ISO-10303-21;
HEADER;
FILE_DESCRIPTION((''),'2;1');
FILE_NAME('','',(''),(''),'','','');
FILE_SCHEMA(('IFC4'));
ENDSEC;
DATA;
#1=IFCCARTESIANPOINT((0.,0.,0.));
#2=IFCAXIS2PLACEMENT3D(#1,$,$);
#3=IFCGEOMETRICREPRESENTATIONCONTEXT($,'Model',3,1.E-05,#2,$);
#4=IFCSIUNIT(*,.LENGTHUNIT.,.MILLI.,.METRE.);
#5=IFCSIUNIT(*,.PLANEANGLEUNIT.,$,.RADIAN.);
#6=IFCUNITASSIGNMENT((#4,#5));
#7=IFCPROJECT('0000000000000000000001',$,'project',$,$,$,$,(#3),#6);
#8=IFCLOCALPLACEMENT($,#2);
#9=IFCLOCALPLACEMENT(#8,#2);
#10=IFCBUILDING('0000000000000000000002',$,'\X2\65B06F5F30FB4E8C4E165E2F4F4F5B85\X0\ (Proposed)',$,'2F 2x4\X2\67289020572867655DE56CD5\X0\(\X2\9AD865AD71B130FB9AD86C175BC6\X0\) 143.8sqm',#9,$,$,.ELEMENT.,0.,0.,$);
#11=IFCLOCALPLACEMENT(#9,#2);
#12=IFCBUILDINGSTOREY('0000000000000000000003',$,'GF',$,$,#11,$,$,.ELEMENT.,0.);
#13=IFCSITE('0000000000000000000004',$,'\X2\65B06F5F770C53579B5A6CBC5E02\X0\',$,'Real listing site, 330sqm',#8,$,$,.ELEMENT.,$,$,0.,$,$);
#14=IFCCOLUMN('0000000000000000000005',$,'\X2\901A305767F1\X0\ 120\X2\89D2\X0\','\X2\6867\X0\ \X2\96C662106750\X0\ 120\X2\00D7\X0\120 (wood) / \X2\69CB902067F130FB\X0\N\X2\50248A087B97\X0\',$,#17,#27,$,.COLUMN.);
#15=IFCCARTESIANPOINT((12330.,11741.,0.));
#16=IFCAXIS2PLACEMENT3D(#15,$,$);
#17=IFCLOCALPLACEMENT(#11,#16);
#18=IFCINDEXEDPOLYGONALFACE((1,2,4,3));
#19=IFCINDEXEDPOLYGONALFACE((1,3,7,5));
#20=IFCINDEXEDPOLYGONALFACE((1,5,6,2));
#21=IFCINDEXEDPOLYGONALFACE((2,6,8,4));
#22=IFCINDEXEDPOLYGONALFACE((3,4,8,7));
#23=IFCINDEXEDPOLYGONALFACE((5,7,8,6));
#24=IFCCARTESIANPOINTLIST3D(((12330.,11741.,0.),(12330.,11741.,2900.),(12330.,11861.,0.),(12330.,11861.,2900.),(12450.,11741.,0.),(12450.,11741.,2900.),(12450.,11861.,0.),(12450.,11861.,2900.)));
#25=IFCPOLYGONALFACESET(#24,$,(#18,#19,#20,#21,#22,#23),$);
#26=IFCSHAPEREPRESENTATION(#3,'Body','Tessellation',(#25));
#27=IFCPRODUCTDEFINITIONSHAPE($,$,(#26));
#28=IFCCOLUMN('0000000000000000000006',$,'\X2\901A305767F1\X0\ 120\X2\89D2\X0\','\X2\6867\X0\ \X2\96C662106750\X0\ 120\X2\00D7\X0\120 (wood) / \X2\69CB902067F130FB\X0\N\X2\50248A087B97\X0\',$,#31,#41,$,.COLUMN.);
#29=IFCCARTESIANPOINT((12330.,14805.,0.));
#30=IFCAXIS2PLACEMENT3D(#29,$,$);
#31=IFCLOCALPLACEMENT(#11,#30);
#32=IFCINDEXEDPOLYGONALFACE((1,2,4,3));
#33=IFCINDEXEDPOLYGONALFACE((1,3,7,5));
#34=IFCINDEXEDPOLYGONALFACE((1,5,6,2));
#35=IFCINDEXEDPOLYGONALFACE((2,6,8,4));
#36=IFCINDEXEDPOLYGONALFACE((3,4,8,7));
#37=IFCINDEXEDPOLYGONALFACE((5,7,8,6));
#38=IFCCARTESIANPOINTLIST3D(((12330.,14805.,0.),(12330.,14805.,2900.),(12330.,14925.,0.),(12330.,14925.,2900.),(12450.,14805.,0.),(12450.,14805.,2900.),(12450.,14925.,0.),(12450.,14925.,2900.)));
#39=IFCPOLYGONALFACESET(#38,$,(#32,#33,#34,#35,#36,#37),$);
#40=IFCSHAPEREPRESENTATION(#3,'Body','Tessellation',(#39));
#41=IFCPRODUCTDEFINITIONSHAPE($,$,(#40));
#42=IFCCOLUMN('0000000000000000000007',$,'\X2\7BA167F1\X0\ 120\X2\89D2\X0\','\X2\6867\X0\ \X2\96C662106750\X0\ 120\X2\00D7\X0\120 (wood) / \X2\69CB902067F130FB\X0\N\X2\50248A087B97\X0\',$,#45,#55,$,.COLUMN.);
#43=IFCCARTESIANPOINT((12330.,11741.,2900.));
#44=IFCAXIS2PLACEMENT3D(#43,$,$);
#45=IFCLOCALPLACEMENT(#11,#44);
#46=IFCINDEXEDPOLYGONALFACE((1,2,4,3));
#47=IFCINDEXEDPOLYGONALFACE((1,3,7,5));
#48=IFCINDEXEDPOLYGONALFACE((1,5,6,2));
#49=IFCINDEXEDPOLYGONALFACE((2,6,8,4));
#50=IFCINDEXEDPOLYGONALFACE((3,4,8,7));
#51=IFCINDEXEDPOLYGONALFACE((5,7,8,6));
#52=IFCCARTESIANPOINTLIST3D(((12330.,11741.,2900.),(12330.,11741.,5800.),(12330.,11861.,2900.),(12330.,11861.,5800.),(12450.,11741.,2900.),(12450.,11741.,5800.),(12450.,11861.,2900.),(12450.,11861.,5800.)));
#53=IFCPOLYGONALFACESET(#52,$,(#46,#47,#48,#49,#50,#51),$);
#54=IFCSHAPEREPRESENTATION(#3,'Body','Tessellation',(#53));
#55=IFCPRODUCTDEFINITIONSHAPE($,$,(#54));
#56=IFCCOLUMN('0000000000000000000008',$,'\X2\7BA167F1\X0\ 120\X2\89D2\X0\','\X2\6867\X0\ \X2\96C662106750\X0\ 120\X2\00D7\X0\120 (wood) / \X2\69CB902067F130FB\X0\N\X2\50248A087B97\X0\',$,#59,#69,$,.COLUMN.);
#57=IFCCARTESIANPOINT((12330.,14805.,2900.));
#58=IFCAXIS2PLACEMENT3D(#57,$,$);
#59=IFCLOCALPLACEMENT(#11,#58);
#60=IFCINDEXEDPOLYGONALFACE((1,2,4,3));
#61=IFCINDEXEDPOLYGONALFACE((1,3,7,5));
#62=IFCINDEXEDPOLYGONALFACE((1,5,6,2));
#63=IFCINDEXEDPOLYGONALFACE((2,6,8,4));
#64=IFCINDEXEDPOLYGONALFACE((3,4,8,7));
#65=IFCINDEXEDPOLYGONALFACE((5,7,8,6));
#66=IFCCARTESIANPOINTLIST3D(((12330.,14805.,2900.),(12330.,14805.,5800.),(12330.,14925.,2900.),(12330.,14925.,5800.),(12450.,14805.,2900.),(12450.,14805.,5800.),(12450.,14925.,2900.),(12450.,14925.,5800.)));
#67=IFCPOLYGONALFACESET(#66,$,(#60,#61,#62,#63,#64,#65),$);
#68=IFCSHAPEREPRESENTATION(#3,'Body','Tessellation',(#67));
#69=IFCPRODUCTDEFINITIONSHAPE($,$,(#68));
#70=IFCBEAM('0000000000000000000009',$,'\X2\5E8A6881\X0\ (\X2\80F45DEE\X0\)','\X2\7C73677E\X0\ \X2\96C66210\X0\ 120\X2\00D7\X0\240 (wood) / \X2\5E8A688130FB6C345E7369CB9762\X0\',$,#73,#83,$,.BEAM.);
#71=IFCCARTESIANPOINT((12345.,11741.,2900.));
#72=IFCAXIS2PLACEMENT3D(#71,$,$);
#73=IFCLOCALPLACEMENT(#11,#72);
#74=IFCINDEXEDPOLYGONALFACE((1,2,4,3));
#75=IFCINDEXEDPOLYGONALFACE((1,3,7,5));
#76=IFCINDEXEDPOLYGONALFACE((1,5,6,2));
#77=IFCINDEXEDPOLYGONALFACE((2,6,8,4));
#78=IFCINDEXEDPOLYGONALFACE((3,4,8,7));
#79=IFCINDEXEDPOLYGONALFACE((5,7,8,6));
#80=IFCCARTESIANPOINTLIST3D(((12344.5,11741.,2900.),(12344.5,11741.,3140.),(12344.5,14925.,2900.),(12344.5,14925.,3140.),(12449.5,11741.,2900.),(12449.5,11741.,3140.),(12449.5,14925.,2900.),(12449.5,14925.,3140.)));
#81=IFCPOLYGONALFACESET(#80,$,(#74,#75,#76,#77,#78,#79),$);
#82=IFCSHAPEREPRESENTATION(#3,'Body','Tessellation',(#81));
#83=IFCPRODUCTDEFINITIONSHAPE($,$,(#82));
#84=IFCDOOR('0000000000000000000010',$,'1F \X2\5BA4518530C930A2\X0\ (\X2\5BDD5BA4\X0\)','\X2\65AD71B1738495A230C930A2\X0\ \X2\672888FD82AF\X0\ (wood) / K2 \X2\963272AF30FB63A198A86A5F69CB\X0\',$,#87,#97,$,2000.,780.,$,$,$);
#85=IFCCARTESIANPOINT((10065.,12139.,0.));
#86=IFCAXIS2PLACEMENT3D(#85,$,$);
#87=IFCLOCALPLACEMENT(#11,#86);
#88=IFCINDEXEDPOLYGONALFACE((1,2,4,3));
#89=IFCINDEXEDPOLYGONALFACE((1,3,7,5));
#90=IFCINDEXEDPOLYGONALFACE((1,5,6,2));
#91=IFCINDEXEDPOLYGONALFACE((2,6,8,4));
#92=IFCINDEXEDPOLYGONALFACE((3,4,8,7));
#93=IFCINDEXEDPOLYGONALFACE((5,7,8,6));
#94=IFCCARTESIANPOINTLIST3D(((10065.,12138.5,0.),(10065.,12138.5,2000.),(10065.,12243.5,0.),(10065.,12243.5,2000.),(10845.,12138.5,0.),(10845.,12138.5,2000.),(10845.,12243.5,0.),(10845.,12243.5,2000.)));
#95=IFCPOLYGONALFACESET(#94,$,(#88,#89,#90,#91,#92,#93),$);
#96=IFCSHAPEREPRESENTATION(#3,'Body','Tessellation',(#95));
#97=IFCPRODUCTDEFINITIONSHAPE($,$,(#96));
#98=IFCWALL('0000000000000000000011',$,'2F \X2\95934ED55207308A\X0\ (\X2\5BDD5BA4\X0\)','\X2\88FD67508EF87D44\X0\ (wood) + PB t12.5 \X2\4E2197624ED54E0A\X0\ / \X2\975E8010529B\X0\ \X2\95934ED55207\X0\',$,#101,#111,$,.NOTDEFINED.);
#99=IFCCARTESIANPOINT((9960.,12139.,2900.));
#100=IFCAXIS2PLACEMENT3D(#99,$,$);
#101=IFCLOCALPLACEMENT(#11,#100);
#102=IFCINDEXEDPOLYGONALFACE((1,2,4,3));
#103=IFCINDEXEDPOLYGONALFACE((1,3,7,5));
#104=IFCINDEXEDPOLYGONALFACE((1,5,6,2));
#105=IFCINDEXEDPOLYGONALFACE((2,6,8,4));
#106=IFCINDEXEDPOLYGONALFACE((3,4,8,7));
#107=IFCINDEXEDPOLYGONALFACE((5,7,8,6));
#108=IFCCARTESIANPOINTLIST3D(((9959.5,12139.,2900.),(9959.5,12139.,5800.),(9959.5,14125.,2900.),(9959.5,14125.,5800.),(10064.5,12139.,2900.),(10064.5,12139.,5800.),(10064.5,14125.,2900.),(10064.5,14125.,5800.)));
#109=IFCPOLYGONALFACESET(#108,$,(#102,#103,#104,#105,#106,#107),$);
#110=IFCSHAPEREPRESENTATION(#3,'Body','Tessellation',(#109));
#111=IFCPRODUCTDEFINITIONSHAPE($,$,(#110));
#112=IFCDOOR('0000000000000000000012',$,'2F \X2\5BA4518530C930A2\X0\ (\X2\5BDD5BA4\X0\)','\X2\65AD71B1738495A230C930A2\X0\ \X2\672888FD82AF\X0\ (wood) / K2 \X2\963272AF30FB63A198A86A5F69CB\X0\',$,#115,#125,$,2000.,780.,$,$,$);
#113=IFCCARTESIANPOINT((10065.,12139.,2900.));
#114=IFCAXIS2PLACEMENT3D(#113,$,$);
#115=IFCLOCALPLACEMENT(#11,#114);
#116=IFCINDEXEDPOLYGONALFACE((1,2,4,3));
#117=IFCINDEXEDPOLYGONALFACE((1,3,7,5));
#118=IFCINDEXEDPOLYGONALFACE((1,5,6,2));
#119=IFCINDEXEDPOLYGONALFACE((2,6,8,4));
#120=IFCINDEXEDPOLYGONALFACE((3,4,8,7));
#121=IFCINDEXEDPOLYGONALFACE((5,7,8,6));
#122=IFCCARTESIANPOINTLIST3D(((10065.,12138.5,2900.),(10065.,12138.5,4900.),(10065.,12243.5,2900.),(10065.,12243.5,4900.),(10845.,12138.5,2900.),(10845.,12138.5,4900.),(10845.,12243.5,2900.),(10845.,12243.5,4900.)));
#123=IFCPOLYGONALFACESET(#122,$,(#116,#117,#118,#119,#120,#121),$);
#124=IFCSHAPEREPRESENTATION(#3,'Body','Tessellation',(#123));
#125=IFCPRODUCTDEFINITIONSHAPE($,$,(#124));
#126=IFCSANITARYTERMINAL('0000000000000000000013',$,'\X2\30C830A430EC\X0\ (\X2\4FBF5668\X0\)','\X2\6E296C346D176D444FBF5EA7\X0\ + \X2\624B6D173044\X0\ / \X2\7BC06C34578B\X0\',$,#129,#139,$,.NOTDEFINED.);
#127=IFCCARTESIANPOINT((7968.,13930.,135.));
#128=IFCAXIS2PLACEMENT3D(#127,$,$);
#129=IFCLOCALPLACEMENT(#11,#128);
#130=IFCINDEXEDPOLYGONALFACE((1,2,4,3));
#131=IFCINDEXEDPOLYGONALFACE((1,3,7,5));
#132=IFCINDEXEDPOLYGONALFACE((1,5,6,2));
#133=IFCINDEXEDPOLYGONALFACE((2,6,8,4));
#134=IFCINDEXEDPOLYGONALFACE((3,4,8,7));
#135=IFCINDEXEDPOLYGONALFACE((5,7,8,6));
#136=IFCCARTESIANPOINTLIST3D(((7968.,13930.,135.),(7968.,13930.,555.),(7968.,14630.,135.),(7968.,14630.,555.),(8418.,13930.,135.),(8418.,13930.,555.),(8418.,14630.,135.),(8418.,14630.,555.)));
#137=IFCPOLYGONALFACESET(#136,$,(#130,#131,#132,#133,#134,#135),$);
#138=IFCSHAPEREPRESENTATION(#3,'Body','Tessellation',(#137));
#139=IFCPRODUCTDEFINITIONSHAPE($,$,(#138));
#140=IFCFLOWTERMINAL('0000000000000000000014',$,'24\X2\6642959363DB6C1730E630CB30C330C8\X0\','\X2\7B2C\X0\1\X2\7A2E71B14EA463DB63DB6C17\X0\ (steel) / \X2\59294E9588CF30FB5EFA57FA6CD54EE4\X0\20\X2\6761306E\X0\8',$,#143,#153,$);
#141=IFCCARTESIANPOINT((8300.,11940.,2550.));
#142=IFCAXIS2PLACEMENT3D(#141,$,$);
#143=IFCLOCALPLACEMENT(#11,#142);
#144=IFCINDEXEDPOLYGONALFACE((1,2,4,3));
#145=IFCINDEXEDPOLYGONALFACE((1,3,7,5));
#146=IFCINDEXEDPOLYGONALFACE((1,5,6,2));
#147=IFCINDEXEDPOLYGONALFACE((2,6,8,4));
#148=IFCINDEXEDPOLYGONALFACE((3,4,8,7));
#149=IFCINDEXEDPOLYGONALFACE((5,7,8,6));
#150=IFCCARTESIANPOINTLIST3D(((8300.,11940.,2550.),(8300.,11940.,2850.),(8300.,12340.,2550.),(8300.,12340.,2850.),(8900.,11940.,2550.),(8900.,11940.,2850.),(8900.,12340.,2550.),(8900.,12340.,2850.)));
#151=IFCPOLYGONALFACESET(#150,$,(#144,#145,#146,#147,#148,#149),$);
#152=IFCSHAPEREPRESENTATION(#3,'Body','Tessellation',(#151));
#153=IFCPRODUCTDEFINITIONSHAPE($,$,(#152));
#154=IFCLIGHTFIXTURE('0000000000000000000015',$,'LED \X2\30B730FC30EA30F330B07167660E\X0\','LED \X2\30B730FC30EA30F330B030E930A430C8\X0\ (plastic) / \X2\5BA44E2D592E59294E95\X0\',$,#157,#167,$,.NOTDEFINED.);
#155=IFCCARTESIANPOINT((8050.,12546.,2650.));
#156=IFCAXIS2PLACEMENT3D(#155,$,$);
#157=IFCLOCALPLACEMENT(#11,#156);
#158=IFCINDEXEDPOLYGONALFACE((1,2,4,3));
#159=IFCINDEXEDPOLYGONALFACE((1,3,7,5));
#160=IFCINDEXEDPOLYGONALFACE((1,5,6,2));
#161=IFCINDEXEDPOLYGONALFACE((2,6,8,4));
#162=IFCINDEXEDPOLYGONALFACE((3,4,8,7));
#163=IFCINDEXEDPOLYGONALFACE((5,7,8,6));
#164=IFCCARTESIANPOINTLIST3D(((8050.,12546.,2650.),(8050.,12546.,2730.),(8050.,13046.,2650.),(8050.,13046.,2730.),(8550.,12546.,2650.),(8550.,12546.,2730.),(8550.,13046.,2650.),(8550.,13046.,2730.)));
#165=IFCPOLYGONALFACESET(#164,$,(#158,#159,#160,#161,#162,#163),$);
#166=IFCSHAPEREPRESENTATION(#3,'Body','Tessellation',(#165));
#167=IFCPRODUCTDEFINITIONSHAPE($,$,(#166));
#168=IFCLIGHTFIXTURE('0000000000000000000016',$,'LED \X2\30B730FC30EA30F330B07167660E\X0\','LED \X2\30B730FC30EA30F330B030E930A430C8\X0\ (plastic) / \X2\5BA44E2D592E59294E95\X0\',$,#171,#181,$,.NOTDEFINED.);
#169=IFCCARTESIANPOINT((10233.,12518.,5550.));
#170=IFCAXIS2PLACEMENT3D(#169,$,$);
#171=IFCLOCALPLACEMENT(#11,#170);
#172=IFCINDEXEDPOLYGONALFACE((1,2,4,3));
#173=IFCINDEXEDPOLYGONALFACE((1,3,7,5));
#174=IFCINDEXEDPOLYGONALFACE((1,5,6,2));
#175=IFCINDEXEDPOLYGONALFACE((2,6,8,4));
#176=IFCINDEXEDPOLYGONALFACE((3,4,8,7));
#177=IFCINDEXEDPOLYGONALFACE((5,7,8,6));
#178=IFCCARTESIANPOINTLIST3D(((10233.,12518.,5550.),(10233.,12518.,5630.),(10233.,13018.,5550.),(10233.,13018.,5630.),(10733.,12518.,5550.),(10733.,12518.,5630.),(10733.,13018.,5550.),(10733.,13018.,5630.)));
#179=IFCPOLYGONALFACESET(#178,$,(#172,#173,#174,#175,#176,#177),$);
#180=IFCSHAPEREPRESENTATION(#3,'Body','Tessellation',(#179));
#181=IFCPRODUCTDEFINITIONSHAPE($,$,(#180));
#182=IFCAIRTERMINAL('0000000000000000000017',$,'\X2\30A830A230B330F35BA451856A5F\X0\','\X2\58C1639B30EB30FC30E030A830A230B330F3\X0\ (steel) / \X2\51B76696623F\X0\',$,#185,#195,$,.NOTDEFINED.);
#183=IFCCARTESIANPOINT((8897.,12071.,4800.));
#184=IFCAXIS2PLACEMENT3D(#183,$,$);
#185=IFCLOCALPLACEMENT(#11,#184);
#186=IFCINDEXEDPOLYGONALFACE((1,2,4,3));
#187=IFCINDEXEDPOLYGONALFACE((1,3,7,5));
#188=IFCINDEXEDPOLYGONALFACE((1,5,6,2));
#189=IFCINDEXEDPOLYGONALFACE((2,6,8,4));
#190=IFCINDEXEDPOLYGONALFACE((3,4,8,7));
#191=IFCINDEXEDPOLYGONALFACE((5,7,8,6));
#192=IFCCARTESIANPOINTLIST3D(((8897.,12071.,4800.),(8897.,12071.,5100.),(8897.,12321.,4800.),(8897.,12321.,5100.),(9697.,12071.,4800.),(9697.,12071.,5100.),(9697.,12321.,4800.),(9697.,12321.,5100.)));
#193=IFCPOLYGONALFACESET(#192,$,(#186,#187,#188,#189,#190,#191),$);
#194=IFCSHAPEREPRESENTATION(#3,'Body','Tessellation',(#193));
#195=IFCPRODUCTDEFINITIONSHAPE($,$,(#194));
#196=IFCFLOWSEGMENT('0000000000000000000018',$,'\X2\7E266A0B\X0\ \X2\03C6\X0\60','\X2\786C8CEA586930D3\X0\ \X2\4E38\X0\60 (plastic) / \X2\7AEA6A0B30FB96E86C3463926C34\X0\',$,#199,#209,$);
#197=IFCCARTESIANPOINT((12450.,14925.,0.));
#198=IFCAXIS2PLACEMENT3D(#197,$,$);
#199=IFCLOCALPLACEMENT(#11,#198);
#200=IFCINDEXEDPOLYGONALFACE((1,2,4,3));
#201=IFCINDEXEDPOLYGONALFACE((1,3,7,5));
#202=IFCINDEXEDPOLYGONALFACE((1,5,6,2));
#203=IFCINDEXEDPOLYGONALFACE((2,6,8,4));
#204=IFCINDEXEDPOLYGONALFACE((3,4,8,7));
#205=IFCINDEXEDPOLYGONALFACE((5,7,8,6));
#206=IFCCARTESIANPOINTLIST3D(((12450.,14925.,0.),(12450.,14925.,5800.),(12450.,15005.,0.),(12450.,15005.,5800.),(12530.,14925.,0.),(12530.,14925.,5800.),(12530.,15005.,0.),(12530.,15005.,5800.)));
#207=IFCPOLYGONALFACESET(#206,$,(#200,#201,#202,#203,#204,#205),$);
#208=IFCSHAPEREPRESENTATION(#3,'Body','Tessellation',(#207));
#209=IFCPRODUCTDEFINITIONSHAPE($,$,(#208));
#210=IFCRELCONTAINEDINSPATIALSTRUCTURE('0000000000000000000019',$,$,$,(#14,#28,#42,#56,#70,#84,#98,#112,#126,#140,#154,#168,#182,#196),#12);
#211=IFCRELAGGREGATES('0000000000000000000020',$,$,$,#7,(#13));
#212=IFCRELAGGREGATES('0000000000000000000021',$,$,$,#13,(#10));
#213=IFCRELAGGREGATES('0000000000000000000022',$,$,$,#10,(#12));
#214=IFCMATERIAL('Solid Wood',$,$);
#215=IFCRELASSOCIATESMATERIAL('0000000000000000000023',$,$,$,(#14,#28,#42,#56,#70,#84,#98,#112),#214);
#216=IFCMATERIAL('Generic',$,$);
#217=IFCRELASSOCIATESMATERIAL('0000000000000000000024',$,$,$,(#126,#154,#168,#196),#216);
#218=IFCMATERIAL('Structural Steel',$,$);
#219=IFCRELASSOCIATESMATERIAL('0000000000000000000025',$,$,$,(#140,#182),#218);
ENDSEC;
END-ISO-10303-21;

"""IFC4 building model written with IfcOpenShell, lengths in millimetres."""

from ifc_helpers import new_model, si_unit, frame, frame_2d, origin, place, context, project, spatial, rectangle, extrude, material, element, save


model = new_model("IFC4")

# Units and contexts
model_context = context("Model", 3, precision=1e-05, world=origin())
ifc_project = project(units=[si_unit("LENGTHUNIT", "METRE", prefix="MILLI"), si_unit("PLANEANGLEUNIT", "RADIAN")], contexts=[model_context])

# Site, building, storey
site_placement = place(None, origin())
site = spatial("IfcSite", under=ifc_project, at=site_placement, Name="新潟県南魚沼市", ObjectType="Real listing site, 330sqm", CompositionType="ELEMENT", RefElevation=0.0)
building_placement = place(site_placement, origin())
building = spatial("IfcBuilding", under=site, at=building_placement, Name="新潟・二世帯住宅 (Proposed)", ObjectType="2F 2x4木造在来工法(高断熱・高気密) 143.8sqm", CompositionType="ELEMENT", ElevationOfRefHeight=0.0, ElevationOfTerrain=0.0)
storey_placement = place(building_placement, origin())
storey = spatial("IfcBuildingStorey", under=building, at=storey_placement, Name="GF", CompositionType="ELEMENT", Elevation=0.0)

# Columns
ifc_material_1 = material(Name="Solid Wood")
column_1_placement = place(storey_placement, frame((12330.0, 11741.0, 0.0)))
element("IfcColumn", 1, at=column_1_placement, inside=storey, material=ifc_material_1, Name="通し柱 120角", Description="桧 集成材 120×120 (wood) / 構造柱・N値計算", PredefinedType="COLUMN", context=model_context, shape_type="SweptSolid", body=[
    extrude(rectangle(XDim=120.0, YDim=120.0, at=frame_2d((60.0, 60.0))), frame((12330.0, 11741.0, 0.0)), (0.0, 0.0, 1.0), 2900.0),
])
column_2_placement = place(storey_placement, frame((12330.0, 14805.0, 0.0)))
element("IfcColumn", 2, at=column_2_placement, inside=storey, material=ifc_material_1, Name="通し柱 120角", Description="桧 集成材 120×120 (wood) / 構造柱・N値計算", PredefinedType="COLUMN", context=model_context, shape_type="SweptSolid", body=[
    extrude(rectangle(XDim=120.0, YDim=120.0, at=frame_2d((60.0, 60.0))), frame((12330.0, 14805.0, 0.0)), (0.0, 0.0, 1.0), 2900.0),
])
column_3_placement = place(storey_placement, frame((12330.0, 11741.0, 2900.0)))
element("IfcColumn", 3, at=column_3_placement, inside=storey, material=ifc_material_1, Name="管柱 120角", Description="桧 集成材 120×120 (wood) / 構造柱・N値計算", PredefinedType="COLUMN", context=model_context, shape_type="SweptSolid", body=[
    extrude(rectangle(XDim=120.0, YDim=120.0, at=frame_2d((60.0, 60.0))), frame((12330.0, 11741.0, 2900.0)), (0.0, 0.0, 1.0), 2900.0),
])
column_4_placement = place(storey_placement, frame((12330.0, 14805.0, 2900.0)))
element("IfcColumn", 4, at=column_4_placement, inside=storey, material=ifc_material_1, Name="管柱 120角", Description="桧 集成材 120×120 (wood) / 構造柱・N値計算", PredefinedType="COLUMN", context=model_context, shape_type="SweptSolid", body=[
    extrude(rectangle(XDim=120.0, YDim=120.0, at=frame_2d((60.0, 60.0))), frame((12330.0, 14805.0, 2900.0)), (0.0, 0.0, 1.0), 2900.0),
])

# Beam
beam_1_placement = place(storey_placement, frame((12345.0, 11741.0, 2900.0)))
element("IfcBeam", 5, at=beam_1_placement, inside=storey, material=ifc_material_1, Name="床梁 (胴差)", Description="米松 集成 120×240 (wood) / 床梁・水平構面", PredefinedType="BEAM", context=model_context, shape_type="SweptSolid", body=[
    extrude(rectangle(XDim=105.0, YDim=3184.0, at=frame_2d((52.0, 1592.0))), frame((12345.0, 11741.0, 2900.0)), (0.0, 0.0, 1.0), 240.0),
])

# Door
door_1_placement = place(storey_placement, frame((10065.0, 12139.0, 0.0)))
element("IfcDoor", 6, at=door_1_placement, inside=storey, material=ifc_material_1, Name="1F 室内ドア (寝室)", Description="断熱玄関ドア 木製芯 (wood) / K2 防犯・採風機構", OverallHeight=2000.0, OverallWidth=780.0, context=model_context, shape_type="SweptSolid", body=[
    extrude(rectangle(XDim=780.0, YDim=105.0, at=frame_2d((390.0, 52.0))), frame((10065.0, 12139.0, 0.0)), (0.0, 0.0, 1.0), 2000.0),
])

# Wall
wall_1_placement = place(storey_placement, frame((9960.0, 12139.0, 2900.0)))
element("IfcWall", 7, at=wall_1_placement, inside=storey, material=ifc_material_1, Name="2F 間仕切り (寝室)", Description="製材軸組 (wood) + PB t12.5 両面仕上 / 非耐力 間仕切", PredefinedType="NOTDEFINED", context=model_context, shape_type="SweptSolid", body=[
    extrude(rectangle(XDim=105.0, YDim=1986.0, at=frame_2d((52.0, 993.0))), frame((9960.0, 12139.0, 2900.0)), (0.0, 0.0, 1.0), 2900.0),
])

# Door
door_2_placement = place(storey_placement, frame((10065.0, 12139.0, 2900.0)))
element("IfcDoor", 8, at=door_2_placement, inside=storey, material=ifc_material_1, Name="2F 室内ドア (寝室)", Description="断熱玄関ドア 木製芯 (wood) / K2 防犯・採風機構", OverallHeight=2000.0, OverallWidth=780.0, context=model_context, shape_type="SweptSolid", body=[
    extrude(rectangle(XDim=780.0, YDim=105.0, at=frame_2d((390.0, 52.0))), frame((10065.0, 12139.0, 2900.0)), (0.0, 0.0, 1.0), 2000.0),
])

# Sanitary terminal
ifc_material_2 = material(Name="Generic")
sanitary_terminal_placement = place(storey_placement, frame((7968.0, 13930.0, 135.0)))
element("IfcSanitaryTerminal", 9, at=sanitary_terminal_placement, inside=storey, material=ifc_material_2, Name="トイレ (便器)", Description="温水洗浄便座 + 手洗い / 節水型", PredefinedType="NOTDEFINED", context=model_context, shape_type="SweptSolid", body=[
    extrude(rectangle(XDim=450.0, YDim=700.0, at=frame_2d((225.0, 350.0))), frame((7968.0, 13930.0, 135.0)), (0.0, 0.0, 1.0), 420.0),
])

# Flow terminal
ifc_material_3 = material(Name="Structural Steel")
flow_terminal_placement = place(storey_placement, frame((8300.0, 11940.0, 2550.0)))
element("IfcFlowTerminal", 10, at=flow_terminal_placement, inside=storey, material=ifc_material_3, Name="24時間換気ユニット", Description="第1種熱交換換気 (steel) / 天井裏・建基法令20条の8", context=model_context, shape_type="SweptSolid", body=[
    extrude(rectangle(XDim=600.0, YDim=400.0, at=frame_2d((300.0, 200.0))), frame((8300.0, 11940.0, 2550.0)), (0.0, 0.0, 1.0), 300.0),
])

# Light fixtures
light_fixture_1_placement = place(storey_placement, frame((8050.0, 12546.0, 2650.0)))
element("IfcLightFixture", 11, at=light_fixture_1_placement, inside=storey, material=ifc_material_2, Name="LED シーリング照明", Description="LED シーリングライト (plastic) / 室中央天井", PredefinedType="NOTDEFINED", context=model_context, shape_type="SweptSolid", body=[
    extrude(rectangle(XDim=500.0, YDim=500.0, at=frame_2d((250.0, 250.0))), frame((8050.0, 12546.0, 2650.0)), (0.0, 0.0, 1.0), 80.0),
])
light_fixture_2_placement = place(storey_placement, frame((10233.0, 12518.0, 5550.0)))
element("IfcLightFixture", 12, at=light_fixture_2_placement, inside=storey, material=ifc_material_2, Name="LED シーリング照明", Description="LED シーリングライト (plastic) / 室中央天井", PredefinedType="NOTDEFINED", context=model_context, shape_type="SweptSolid", body=[
    extrude(rectangle(XDim=500.0, YDim=500.0, at=frame_2d((250.0, 250.0))), frame((10233.0, 12518.0, 5550.0)), (0.0, 0.0, 1.0), 80.0),
])

# Air terminal
air_terminal_placement = place(storey_placement, frame((8897.0, 12071.0, 4800.0)))
element("IfcAirTerminal", 13, at=air_terminal_placement, inside=storey, material=ifc_material_3, Name="エアコン室内機", Description="壁掛ルームエアコン (steel) / 冷暖房", PredefinedType="NOTDEFINED", context=model_context, shape_type="SweptSolid", body=[
    extrude(rectangle(XDim=800.0, YDim=250.0, at=frame_2d((400.0, 125.0))), frame((8897.0, 12071.0, 4800.0)), (0.0, 0.0, 1.0), 300.0),
])

# Flow segment
flow_segment_placement = place(storey_placement, frame((12450.0, 14925.0, 0.0)))
element("IfcFlowSegment", 14, at=flow_segment_placement, inside=storey, material=ifc_material_2, Name="縦樋 φ60", Description="硬質塩ビ 丸60 (plastic) / 竪樋・雨水排水", context=model_context, shape_type="SweptSolid", body=[
    extrude(rectangle(XDim=80.0, YDim=80.0, at=frame_2d((40.0, 40.0))), frame((12450.0, 14925.0, 0.0)), (0.0, 0.0, 1.0), 5800.0),
])

save(model, "model.ifc")
